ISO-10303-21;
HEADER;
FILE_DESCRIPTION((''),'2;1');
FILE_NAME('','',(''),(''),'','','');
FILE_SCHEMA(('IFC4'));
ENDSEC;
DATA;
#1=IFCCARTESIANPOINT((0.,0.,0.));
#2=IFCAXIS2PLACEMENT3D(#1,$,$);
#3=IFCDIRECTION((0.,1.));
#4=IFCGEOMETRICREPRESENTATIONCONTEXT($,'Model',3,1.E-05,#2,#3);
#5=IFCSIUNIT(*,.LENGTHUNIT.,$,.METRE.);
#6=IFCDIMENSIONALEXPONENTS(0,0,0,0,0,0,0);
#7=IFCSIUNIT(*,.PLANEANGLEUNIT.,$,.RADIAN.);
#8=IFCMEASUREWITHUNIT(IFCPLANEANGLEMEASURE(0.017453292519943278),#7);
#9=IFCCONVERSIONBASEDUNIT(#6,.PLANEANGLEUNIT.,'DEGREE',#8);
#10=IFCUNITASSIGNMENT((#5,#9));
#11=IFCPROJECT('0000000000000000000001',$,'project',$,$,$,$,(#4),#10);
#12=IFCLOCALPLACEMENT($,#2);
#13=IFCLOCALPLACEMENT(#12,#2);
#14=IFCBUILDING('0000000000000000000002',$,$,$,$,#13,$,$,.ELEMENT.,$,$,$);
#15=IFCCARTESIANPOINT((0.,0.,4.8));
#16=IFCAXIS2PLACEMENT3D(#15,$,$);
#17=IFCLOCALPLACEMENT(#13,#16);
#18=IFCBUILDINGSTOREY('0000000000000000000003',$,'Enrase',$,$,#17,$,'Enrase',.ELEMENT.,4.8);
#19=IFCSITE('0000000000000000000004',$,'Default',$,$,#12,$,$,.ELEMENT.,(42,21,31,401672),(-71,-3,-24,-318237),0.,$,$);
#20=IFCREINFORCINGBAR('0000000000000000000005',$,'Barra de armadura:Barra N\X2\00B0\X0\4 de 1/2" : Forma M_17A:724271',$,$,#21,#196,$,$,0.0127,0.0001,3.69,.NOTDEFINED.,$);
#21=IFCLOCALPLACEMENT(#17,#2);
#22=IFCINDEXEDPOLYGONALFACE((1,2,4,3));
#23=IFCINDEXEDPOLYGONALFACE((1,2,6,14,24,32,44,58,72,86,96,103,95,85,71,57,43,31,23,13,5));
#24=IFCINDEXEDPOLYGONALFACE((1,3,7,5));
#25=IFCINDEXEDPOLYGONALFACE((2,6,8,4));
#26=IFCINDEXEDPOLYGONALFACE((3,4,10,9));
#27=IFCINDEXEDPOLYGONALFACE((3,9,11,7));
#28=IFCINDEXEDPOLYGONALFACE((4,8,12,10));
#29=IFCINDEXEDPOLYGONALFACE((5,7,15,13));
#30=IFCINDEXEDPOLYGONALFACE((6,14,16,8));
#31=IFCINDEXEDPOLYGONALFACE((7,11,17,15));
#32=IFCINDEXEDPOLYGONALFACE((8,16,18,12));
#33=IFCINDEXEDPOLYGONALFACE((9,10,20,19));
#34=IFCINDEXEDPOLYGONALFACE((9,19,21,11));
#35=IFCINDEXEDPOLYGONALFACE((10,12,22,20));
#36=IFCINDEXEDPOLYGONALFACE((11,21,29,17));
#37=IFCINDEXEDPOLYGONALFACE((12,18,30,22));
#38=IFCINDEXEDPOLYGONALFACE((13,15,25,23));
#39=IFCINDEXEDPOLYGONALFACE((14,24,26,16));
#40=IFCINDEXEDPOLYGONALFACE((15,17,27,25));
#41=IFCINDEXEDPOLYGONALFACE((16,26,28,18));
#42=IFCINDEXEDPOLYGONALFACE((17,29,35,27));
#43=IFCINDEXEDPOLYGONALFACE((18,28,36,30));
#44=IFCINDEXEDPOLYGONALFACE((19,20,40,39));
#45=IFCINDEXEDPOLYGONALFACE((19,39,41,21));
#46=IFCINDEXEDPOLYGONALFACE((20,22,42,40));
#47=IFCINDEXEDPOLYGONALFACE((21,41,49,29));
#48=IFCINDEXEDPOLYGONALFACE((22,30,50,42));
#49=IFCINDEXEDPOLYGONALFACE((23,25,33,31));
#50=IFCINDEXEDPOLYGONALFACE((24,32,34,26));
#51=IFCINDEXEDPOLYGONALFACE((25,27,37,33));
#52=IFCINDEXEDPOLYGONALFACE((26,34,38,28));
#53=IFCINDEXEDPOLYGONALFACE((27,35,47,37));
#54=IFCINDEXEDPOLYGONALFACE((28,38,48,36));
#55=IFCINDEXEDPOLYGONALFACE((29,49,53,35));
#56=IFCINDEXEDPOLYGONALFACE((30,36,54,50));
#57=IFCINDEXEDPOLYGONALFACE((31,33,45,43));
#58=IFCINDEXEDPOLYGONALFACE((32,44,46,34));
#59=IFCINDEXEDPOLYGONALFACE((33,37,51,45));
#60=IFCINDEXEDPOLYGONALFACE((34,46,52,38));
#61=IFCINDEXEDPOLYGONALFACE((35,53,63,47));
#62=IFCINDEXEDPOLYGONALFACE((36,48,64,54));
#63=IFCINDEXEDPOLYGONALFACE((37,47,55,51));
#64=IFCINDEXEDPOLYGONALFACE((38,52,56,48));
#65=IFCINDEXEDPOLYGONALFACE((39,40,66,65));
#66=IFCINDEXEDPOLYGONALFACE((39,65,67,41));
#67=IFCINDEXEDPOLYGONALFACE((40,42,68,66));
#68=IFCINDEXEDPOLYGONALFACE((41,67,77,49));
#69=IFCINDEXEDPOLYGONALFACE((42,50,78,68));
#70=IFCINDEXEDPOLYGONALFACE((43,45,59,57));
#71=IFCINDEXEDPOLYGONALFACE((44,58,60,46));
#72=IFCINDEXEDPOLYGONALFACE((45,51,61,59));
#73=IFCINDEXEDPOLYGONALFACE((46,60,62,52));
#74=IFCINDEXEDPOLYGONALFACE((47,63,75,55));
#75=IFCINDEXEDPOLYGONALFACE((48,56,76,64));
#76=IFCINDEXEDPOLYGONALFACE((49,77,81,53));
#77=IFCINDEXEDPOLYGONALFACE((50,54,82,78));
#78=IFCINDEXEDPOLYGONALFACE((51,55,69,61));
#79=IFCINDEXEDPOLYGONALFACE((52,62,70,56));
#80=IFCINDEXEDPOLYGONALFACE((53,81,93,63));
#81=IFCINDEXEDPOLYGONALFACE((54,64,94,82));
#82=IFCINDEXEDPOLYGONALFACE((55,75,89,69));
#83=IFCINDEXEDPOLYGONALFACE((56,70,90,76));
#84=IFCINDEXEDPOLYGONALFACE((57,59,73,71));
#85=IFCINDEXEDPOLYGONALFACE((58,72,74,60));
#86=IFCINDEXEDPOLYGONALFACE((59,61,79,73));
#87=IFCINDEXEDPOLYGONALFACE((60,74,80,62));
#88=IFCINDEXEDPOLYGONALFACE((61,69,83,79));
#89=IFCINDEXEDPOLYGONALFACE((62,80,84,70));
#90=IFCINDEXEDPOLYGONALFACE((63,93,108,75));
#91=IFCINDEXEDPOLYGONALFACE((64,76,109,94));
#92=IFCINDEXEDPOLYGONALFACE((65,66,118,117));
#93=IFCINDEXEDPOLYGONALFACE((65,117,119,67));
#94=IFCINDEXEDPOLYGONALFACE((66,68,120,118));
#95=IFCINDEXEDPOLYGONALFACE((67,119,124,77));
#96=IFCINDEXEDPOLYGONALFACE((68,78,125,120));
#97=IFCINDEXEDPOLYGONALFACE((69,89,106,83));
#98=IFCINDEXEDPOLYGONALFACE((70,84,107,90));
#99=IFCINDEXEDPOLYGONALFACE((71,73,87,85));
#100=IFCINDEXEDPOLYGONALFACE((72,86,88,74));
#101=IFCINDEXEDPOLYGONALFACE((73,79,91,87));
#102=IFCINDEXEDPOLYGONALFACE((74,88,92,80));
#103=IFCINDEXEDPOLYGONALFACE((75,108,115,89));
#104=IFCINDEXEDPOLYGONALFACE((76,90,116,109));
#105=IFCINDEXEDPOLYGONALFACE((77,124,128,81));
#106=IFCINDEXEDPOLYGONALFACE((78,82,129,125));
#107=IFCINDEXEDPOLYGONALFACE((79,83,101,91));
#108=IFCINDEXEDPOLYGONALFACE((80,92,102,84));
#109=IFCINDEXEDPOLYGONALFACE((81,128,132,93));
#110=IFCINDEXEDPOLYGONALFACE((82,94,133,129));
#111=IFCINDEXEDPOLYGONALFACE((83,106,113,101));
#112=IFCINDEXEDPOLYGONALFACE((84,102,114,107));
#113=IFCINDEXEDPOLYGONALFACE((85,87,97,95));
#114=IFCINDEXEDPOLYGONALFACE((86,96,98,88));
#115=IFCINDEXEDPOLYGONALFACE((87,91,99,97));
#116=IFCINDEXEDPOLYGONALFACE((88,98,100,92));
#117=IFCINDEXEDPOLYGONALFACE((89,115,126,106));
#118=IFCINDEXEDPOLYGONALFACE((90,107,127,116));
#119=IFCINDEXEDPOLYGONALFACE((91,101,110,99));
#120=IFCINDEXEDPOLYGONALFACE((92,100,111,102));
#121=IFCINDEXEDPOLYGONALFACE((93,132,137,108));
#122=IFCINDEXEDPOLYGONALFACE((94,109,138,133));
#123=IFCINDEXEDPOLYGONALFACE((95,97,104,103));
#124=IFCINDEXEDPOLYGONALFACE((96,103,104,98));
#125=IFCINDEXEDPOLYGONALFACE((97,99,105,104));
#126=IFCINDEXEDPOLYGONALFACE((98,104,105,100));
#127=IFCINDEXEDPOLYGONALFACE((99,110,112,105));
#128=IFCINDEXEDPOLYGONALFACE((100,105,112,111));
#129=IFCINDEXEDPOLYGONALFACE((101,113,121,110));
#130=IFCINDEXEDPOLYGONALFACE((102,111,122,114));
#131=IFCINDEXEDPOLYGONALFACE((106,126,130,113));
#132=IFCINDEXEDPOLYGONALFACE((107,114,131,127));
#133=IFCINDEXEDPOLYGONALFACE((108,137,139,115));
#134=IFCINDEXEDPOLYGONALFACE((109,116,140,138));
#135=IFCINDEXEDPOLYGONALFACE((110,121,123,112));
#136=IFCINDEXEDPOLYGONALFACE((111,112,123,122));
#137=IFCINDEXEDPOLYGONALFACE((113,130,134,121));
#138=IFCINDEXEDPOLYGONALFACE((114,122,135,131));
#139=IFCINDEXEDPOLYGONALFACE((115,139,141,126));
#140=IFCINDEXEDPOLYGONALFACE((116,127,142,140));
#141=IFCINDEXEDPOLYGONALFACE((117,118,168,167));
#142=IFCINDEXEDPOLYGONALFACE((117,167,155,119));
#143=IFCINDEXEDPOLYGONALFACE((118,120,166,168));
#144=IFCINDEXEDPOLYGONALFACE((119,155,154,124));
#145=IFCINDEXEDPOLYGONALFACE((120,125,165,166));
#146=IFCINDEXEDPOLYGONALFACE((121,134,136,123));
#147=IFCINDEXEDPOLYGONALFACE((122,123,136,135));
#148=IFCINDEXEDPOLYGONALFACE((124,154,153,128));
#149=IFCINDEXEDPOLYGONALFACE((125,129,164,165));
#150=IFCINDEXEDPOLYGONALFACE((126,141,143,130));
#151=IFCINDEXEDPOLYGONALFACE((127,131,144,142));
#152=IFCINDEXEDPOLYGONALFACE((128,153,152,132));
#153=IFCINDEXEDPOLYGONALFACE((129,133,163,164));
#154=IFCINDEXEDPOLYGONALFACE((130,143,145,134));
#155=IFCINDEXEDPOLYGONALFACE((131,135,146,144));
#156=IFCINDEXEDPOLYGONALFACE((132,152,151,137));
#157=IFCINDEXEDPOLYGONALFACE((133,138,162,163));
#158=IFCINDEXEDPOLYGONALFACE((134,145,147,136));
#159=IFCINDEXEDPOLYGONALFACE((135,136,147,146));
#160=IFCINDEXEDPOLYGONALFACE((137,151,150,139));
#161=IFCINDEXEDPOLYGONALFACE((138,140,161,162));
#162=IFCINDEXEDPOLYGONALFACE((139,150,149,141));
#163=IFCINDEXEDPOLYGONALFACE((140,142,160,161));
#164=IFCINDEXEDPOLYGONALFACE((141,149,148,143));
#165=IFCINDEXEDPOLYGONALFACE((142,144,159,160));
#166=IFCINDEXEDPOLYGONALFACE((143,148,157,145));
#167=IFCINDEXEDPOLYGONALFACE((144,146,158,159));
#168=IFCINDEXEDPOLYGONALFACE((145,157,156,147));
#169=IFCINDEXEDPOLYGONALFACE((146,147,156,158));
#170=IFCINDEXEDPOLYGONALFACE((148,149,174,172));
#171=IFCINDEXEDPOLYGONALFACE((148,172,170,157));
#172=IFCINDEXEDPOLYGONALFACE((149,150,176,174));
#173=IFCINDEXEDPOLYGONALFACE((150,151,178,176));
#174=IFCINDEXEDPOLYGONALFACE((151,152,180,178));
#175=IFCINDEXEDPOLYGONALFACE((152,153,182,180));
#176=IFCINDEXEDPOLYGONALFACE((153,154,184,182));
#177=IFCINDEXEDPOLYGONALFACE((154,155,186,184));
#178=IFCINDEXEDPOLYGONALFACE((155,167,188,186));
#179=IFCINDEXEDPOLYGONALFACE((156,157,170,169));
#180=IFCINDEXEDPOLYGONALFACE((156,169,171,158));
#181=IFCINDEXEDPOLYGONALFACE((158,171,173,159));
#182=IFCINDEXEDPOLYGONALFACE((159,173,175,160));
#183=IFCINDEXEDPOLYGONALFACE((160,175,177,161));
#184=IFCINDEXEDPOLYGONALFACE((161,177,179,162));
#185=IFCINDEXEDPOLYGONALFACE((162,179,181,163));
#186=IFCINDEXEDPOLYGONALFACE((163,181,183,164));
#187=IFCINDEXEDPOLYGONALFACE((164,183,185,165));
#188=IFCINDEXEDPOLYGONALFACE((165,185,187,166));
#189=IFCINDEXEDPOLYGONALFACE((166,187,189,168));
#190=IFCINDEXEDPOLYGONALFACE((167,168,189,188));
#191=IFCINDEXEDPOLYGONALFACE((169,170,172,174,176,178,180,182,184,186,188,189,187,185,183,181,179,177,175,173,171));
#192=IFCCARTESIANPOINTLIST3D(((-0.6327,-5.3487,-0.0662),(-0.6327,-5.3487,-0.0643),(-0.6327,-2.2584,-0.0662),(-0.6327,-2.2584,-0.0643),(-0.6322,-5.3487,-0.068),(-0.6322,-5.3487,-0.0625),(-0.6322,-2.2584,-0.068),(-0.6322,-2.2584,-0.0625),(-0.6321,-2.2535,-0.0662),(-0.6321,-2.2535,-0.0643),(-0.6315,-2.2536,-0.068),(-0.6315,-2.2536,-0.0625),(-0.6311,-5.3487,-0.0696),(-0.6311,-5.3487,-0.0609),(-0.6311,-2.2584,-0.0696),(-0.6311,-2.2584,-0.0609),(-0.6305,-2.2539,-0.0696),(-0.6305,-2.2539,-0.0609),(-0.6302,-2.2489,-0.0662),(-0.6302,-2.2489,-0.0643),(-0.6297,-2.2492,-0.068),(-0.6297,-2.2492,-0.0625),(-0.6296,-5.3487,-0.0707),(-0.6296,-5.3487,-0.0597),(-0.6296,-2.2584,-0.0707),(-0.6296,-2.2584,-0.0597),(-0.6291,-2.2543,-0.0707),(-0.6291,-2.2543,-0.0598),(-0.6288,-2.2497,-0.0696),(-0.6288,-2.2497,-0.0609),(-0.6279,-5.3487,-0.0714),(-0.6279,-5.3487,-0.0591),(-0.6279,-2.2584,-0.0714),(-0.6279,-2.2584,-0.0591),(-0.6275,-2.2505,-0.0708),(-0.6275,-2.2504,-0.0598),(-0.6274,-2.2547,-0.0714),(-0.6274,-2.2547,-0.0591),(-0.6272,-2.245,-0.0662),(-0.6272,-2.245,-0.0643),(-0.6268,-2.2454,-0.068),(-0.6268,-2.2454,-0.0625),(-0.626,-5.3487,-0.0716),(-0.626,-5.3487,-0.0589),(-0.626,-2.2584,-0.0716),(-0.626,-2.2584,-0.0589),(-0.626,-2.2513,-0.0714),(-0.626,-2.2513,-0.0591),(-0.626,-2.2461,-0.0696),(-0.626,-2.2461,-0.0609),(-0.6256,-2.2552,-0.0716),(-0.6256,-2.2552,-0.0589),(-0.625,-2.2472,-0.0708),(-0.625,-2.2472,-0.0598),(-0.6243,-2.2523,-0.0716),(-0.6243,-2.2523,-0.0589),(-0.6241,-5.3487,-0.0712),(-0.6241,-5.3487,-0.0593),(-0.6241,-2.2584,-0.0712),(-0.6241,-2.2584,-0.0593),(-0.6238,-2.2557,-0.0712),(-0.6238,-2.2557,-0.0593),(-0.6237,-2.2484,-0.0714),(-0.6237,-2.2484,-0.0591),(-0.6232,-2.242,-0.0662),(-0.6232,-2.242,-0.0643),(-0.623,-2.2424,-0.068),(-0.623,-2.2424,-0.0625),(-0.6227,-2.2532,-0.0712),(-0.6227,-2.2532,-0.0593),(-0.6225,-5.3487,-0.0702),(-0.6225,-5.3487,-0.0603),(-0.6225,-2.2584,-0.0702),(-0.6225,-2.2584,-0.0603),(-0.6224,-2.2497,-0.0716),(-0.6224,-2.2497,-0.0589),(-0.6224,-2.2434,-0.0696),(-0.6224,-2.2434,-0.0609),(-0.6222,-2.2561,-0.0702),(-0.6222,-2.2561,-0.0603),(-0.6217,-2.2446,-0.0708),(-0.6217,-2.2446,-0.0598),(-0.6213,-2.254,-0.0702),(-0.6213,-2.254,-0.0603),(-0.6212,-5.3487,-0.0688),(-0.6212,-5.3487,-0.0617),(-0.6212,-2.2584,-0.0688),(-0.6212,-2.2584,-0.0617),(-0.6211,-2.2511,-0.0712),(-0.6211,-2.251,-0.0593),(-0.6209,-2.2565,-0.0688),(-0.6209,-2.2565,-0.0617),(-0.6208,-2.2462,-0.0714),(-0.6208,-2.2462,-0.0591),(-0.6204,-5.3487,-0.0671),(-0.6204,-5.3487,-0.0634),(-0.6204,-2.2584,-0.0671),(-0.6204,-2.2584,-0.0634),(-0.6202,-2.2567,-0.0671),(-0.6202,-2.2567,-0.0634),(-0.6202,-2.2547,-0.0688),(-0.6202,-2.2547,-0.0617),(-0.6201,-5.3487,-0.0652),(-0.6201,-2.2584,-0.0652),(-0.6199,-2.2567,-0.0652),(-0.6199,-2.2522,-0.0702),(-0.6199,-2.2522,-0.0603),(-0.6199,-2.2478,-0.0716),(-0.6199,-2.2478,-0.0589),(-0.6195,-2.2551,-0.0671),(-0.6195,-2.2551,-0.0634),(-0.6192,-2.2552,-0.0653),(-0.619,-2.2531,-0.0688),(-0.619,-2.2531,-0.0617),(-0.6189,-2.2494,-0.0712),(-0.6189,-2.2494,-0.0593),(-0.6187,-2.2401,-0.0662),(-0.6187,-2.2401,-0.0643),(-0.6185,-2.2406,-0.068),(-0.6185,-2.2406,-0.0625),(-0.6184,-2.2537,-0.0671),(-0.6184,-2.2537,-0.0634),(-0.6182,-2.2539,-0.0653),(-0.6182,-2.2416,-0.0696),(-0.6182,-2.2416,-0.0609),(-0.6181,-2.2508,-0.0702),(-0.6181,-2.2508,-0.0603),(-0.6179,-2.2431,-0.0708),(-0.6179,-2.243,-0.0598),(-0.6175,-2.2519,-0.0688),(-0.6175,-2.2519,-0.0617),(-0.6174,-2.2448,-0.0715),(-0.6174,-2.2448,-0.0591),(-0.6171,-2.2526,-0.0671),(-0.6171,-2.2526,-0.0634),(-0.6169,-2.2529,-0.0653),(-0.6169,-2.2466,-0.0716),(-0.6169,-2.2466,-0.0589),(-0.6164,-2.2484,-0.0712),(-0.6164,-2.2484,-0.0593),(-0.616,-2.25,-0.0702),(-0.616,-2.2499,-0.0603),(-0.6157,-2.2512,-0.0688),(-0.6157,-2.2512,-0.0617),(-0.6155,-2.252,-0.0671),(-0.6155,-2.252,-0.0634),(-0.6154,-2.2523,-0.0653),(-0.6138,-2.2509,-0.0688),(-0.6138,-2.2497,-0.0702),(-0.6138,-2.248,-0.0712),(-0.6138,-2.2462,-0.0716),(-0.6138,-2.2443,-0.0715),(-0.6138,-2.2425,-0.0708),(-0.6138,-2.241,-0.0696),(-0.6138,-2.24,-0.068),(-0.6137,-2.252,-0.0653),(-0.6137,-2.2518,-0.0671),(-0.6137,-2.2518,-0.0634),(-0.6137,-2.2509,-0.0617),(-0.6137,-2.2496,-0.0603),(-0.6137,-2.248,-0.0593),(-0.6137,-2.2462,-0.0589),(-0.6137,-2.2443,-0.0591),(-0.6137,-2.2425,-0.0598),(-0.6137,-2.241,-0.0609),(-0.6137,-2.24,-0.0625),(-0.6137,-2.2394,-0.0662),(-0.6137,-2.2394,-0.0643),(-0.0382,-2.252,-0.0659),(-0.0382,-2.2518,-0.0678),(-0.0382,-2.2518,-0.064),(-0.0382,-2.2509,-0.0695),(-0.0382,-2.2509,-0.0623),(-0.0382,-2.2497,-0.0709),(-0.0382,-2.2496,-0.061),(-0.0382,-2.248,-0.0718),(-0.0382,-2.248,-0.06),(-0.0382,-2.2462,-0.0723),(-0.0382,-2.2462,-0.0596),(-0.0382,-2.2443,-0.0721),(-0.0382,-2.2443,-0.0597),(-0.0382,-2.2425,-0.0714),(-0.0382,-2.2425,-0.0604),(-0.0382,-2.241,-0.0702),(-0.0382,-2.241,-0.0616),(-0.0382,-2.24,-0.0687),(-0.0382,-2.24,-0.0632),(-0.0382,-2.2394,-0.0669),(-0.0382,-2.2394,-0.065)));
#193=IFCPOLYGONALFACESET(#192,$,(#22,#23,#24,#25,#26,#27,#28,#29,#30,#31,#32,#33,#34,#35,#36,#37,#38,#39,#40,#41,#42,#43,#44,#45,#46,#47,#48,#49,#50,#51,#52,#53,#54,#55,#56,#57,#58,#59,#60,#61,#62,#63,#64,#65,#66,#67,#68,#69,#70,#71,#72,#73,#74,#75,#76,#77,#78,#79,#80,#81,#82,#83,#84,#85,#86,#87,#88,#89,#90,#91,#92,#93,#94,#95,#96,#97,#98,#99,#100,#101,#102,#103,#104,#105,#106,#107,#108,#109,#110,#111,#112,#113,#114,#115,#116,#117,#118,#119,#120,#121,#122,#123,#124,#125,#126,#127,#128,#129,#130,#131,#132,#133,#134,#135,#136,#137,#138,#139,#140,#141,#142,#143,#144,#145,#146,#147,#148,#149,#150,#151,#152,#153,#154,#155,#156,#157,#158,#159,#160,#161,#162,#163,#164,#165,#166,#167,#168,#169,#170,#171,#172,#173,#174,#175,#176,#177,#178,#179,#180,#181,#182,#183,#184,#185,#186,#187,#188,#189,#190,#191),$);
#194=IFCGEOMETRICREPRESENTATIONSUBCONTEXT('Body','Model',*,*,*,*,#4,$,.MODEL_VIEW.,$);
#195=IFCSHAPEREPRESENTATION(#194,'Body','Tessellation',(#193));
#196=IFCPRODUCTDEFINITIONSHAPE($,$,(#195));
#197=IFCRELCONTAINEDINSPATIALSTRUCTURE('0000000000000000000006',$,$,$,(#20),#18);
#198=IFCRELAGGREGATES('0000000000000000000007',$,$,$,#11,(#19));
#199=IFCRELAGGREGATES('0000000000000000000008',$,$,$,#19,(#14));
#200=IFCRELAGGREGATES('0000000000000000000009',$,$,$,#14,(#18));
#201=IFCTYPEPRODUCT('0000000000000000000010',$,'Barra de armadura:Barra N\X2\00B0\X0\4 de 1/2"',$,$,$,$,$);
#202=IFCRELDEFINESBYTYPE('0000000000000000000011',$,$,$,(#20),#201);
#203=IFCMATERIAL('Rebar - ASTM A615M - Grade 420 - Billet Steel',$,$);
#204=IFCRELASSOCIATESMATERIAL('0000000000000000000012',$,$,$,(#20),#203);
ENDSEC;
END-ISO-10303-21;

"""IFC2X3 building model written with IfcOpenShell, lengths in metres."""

from ifc_helpers import new_model, entity, si_unit, converted_unit, direction, frame, origin, place, context, subcontext, project, spatial, material, type_object, element, save


model = new_model("IFC2X3")

# Units and contexts
model_context = context("Model", 3, precision=1e-05, world=origin(), true_north=direction((0.0, 1.0)))
body_context = subcontext(model_context, "Body", "Model", "MODEL_VIEW")
ifc_project = project(units=[si_unit("LENGTHUNIT", "METRE"), converted_unit("PLANEANGLEUNIT", "DEGREE", entity("IfcPlaneAngleMeasure", 0.017453292519943278), si_unit("PLANEANGLEUNIT", "RADIAN"), dimensions=[0, 0, 0, 0, 0, 0, 0])], contexts=[model_context])

# Site, building, storey
site_placement = place(None, origin())
site = spatial("IfcSite", under=ifc_project, at=site_placement, Name="Default", CompositionType="ELEMENT", RefLatitude=(42, 21, 31, 401672), RefLongitude=(-71, -3, -24, -318237), RefElevation=0.0)
building_placement = place(site_placement, origin())
building = spatial("IfcBuilding", under=site, at=building_placement, CompositionType="ELEMENT")
storey_placement = place(building_placement, frame((0.0, 0.0, 4.8)))
storey = spatial("IfcBuildingStorey", under=building, at=storey_placement, Name="Enrase", LongName="Enrase", CompositionType="ELEMENT", Elevation=4.8)

# Reinforcing bar
ifc_material = material(Name="Rebar - ASTM A615M - Grade 420 - Billet Steel")
type_product_1 = type_object("IfcTypeProduct", Name="Barra de armadura:Barra N°4 de 1/2\"")
reinforcing_bar_1_placement = place(storey_placement, origin())
element("IfcReinforcingBar", 1, at=reinforcing_bar_1_placement, inside=storey, type_object=type_product_1, material=ifc_material, Name="Barra de armadura:Barra N°4 de 1/2\" : Forma M_17A:724271", BarLength=3.69, BarRole="NOTDEFINED", CrossSectionArea=0.0001, NominalDiameter=0.0127, context=body_context, shape_type="AdvancedSweptSolid", body=[
    entity("IfcSweptDiskSolid", entity("IfcCompositeCurve", [entity("IfcCompositeCurveSegment", "CONTINUOUS", True, entity("IfcPolyline", [entity("IfcCartesianPoint", [-0.6264, -5.3487, -0.0652]), entity("IfcCartesianPoint", [-0.6264, -2.2584, -0.0652])])), entity("IfcCompositeCurveSegment", "CONTINUOUS", True, entity("IfcTrimmedCurve", entity("IfcCircle", entity("IfcAxis2Placement3D", entity("IfcCartesianPoint", [-0.6137, -2.2584, -0.0653]), entity("IfcDirection", [-0.001144, 0.0, -0.999999]), entity("IfcDirection", [0.0, 1.0, 0.0])), 0.0127), [entity("IfcParameterValue", 270.0)], [entity("IfcParameterValue", 360.0)], True, "PARAMETER")), entity("IfcCompositeCurveSegment", "CONTINUOUS", True, entity("IfcPolyline", [entity("IfcCartesianPoint", [-0.6137, -2.2457, -0.0653]), entity("IfcCartesianPoint", [-0.0382, -2.2457, -0.0659])]))], False), 0.0063, None, 0.0, 92.0),
])

save(model, "model.ifc")
